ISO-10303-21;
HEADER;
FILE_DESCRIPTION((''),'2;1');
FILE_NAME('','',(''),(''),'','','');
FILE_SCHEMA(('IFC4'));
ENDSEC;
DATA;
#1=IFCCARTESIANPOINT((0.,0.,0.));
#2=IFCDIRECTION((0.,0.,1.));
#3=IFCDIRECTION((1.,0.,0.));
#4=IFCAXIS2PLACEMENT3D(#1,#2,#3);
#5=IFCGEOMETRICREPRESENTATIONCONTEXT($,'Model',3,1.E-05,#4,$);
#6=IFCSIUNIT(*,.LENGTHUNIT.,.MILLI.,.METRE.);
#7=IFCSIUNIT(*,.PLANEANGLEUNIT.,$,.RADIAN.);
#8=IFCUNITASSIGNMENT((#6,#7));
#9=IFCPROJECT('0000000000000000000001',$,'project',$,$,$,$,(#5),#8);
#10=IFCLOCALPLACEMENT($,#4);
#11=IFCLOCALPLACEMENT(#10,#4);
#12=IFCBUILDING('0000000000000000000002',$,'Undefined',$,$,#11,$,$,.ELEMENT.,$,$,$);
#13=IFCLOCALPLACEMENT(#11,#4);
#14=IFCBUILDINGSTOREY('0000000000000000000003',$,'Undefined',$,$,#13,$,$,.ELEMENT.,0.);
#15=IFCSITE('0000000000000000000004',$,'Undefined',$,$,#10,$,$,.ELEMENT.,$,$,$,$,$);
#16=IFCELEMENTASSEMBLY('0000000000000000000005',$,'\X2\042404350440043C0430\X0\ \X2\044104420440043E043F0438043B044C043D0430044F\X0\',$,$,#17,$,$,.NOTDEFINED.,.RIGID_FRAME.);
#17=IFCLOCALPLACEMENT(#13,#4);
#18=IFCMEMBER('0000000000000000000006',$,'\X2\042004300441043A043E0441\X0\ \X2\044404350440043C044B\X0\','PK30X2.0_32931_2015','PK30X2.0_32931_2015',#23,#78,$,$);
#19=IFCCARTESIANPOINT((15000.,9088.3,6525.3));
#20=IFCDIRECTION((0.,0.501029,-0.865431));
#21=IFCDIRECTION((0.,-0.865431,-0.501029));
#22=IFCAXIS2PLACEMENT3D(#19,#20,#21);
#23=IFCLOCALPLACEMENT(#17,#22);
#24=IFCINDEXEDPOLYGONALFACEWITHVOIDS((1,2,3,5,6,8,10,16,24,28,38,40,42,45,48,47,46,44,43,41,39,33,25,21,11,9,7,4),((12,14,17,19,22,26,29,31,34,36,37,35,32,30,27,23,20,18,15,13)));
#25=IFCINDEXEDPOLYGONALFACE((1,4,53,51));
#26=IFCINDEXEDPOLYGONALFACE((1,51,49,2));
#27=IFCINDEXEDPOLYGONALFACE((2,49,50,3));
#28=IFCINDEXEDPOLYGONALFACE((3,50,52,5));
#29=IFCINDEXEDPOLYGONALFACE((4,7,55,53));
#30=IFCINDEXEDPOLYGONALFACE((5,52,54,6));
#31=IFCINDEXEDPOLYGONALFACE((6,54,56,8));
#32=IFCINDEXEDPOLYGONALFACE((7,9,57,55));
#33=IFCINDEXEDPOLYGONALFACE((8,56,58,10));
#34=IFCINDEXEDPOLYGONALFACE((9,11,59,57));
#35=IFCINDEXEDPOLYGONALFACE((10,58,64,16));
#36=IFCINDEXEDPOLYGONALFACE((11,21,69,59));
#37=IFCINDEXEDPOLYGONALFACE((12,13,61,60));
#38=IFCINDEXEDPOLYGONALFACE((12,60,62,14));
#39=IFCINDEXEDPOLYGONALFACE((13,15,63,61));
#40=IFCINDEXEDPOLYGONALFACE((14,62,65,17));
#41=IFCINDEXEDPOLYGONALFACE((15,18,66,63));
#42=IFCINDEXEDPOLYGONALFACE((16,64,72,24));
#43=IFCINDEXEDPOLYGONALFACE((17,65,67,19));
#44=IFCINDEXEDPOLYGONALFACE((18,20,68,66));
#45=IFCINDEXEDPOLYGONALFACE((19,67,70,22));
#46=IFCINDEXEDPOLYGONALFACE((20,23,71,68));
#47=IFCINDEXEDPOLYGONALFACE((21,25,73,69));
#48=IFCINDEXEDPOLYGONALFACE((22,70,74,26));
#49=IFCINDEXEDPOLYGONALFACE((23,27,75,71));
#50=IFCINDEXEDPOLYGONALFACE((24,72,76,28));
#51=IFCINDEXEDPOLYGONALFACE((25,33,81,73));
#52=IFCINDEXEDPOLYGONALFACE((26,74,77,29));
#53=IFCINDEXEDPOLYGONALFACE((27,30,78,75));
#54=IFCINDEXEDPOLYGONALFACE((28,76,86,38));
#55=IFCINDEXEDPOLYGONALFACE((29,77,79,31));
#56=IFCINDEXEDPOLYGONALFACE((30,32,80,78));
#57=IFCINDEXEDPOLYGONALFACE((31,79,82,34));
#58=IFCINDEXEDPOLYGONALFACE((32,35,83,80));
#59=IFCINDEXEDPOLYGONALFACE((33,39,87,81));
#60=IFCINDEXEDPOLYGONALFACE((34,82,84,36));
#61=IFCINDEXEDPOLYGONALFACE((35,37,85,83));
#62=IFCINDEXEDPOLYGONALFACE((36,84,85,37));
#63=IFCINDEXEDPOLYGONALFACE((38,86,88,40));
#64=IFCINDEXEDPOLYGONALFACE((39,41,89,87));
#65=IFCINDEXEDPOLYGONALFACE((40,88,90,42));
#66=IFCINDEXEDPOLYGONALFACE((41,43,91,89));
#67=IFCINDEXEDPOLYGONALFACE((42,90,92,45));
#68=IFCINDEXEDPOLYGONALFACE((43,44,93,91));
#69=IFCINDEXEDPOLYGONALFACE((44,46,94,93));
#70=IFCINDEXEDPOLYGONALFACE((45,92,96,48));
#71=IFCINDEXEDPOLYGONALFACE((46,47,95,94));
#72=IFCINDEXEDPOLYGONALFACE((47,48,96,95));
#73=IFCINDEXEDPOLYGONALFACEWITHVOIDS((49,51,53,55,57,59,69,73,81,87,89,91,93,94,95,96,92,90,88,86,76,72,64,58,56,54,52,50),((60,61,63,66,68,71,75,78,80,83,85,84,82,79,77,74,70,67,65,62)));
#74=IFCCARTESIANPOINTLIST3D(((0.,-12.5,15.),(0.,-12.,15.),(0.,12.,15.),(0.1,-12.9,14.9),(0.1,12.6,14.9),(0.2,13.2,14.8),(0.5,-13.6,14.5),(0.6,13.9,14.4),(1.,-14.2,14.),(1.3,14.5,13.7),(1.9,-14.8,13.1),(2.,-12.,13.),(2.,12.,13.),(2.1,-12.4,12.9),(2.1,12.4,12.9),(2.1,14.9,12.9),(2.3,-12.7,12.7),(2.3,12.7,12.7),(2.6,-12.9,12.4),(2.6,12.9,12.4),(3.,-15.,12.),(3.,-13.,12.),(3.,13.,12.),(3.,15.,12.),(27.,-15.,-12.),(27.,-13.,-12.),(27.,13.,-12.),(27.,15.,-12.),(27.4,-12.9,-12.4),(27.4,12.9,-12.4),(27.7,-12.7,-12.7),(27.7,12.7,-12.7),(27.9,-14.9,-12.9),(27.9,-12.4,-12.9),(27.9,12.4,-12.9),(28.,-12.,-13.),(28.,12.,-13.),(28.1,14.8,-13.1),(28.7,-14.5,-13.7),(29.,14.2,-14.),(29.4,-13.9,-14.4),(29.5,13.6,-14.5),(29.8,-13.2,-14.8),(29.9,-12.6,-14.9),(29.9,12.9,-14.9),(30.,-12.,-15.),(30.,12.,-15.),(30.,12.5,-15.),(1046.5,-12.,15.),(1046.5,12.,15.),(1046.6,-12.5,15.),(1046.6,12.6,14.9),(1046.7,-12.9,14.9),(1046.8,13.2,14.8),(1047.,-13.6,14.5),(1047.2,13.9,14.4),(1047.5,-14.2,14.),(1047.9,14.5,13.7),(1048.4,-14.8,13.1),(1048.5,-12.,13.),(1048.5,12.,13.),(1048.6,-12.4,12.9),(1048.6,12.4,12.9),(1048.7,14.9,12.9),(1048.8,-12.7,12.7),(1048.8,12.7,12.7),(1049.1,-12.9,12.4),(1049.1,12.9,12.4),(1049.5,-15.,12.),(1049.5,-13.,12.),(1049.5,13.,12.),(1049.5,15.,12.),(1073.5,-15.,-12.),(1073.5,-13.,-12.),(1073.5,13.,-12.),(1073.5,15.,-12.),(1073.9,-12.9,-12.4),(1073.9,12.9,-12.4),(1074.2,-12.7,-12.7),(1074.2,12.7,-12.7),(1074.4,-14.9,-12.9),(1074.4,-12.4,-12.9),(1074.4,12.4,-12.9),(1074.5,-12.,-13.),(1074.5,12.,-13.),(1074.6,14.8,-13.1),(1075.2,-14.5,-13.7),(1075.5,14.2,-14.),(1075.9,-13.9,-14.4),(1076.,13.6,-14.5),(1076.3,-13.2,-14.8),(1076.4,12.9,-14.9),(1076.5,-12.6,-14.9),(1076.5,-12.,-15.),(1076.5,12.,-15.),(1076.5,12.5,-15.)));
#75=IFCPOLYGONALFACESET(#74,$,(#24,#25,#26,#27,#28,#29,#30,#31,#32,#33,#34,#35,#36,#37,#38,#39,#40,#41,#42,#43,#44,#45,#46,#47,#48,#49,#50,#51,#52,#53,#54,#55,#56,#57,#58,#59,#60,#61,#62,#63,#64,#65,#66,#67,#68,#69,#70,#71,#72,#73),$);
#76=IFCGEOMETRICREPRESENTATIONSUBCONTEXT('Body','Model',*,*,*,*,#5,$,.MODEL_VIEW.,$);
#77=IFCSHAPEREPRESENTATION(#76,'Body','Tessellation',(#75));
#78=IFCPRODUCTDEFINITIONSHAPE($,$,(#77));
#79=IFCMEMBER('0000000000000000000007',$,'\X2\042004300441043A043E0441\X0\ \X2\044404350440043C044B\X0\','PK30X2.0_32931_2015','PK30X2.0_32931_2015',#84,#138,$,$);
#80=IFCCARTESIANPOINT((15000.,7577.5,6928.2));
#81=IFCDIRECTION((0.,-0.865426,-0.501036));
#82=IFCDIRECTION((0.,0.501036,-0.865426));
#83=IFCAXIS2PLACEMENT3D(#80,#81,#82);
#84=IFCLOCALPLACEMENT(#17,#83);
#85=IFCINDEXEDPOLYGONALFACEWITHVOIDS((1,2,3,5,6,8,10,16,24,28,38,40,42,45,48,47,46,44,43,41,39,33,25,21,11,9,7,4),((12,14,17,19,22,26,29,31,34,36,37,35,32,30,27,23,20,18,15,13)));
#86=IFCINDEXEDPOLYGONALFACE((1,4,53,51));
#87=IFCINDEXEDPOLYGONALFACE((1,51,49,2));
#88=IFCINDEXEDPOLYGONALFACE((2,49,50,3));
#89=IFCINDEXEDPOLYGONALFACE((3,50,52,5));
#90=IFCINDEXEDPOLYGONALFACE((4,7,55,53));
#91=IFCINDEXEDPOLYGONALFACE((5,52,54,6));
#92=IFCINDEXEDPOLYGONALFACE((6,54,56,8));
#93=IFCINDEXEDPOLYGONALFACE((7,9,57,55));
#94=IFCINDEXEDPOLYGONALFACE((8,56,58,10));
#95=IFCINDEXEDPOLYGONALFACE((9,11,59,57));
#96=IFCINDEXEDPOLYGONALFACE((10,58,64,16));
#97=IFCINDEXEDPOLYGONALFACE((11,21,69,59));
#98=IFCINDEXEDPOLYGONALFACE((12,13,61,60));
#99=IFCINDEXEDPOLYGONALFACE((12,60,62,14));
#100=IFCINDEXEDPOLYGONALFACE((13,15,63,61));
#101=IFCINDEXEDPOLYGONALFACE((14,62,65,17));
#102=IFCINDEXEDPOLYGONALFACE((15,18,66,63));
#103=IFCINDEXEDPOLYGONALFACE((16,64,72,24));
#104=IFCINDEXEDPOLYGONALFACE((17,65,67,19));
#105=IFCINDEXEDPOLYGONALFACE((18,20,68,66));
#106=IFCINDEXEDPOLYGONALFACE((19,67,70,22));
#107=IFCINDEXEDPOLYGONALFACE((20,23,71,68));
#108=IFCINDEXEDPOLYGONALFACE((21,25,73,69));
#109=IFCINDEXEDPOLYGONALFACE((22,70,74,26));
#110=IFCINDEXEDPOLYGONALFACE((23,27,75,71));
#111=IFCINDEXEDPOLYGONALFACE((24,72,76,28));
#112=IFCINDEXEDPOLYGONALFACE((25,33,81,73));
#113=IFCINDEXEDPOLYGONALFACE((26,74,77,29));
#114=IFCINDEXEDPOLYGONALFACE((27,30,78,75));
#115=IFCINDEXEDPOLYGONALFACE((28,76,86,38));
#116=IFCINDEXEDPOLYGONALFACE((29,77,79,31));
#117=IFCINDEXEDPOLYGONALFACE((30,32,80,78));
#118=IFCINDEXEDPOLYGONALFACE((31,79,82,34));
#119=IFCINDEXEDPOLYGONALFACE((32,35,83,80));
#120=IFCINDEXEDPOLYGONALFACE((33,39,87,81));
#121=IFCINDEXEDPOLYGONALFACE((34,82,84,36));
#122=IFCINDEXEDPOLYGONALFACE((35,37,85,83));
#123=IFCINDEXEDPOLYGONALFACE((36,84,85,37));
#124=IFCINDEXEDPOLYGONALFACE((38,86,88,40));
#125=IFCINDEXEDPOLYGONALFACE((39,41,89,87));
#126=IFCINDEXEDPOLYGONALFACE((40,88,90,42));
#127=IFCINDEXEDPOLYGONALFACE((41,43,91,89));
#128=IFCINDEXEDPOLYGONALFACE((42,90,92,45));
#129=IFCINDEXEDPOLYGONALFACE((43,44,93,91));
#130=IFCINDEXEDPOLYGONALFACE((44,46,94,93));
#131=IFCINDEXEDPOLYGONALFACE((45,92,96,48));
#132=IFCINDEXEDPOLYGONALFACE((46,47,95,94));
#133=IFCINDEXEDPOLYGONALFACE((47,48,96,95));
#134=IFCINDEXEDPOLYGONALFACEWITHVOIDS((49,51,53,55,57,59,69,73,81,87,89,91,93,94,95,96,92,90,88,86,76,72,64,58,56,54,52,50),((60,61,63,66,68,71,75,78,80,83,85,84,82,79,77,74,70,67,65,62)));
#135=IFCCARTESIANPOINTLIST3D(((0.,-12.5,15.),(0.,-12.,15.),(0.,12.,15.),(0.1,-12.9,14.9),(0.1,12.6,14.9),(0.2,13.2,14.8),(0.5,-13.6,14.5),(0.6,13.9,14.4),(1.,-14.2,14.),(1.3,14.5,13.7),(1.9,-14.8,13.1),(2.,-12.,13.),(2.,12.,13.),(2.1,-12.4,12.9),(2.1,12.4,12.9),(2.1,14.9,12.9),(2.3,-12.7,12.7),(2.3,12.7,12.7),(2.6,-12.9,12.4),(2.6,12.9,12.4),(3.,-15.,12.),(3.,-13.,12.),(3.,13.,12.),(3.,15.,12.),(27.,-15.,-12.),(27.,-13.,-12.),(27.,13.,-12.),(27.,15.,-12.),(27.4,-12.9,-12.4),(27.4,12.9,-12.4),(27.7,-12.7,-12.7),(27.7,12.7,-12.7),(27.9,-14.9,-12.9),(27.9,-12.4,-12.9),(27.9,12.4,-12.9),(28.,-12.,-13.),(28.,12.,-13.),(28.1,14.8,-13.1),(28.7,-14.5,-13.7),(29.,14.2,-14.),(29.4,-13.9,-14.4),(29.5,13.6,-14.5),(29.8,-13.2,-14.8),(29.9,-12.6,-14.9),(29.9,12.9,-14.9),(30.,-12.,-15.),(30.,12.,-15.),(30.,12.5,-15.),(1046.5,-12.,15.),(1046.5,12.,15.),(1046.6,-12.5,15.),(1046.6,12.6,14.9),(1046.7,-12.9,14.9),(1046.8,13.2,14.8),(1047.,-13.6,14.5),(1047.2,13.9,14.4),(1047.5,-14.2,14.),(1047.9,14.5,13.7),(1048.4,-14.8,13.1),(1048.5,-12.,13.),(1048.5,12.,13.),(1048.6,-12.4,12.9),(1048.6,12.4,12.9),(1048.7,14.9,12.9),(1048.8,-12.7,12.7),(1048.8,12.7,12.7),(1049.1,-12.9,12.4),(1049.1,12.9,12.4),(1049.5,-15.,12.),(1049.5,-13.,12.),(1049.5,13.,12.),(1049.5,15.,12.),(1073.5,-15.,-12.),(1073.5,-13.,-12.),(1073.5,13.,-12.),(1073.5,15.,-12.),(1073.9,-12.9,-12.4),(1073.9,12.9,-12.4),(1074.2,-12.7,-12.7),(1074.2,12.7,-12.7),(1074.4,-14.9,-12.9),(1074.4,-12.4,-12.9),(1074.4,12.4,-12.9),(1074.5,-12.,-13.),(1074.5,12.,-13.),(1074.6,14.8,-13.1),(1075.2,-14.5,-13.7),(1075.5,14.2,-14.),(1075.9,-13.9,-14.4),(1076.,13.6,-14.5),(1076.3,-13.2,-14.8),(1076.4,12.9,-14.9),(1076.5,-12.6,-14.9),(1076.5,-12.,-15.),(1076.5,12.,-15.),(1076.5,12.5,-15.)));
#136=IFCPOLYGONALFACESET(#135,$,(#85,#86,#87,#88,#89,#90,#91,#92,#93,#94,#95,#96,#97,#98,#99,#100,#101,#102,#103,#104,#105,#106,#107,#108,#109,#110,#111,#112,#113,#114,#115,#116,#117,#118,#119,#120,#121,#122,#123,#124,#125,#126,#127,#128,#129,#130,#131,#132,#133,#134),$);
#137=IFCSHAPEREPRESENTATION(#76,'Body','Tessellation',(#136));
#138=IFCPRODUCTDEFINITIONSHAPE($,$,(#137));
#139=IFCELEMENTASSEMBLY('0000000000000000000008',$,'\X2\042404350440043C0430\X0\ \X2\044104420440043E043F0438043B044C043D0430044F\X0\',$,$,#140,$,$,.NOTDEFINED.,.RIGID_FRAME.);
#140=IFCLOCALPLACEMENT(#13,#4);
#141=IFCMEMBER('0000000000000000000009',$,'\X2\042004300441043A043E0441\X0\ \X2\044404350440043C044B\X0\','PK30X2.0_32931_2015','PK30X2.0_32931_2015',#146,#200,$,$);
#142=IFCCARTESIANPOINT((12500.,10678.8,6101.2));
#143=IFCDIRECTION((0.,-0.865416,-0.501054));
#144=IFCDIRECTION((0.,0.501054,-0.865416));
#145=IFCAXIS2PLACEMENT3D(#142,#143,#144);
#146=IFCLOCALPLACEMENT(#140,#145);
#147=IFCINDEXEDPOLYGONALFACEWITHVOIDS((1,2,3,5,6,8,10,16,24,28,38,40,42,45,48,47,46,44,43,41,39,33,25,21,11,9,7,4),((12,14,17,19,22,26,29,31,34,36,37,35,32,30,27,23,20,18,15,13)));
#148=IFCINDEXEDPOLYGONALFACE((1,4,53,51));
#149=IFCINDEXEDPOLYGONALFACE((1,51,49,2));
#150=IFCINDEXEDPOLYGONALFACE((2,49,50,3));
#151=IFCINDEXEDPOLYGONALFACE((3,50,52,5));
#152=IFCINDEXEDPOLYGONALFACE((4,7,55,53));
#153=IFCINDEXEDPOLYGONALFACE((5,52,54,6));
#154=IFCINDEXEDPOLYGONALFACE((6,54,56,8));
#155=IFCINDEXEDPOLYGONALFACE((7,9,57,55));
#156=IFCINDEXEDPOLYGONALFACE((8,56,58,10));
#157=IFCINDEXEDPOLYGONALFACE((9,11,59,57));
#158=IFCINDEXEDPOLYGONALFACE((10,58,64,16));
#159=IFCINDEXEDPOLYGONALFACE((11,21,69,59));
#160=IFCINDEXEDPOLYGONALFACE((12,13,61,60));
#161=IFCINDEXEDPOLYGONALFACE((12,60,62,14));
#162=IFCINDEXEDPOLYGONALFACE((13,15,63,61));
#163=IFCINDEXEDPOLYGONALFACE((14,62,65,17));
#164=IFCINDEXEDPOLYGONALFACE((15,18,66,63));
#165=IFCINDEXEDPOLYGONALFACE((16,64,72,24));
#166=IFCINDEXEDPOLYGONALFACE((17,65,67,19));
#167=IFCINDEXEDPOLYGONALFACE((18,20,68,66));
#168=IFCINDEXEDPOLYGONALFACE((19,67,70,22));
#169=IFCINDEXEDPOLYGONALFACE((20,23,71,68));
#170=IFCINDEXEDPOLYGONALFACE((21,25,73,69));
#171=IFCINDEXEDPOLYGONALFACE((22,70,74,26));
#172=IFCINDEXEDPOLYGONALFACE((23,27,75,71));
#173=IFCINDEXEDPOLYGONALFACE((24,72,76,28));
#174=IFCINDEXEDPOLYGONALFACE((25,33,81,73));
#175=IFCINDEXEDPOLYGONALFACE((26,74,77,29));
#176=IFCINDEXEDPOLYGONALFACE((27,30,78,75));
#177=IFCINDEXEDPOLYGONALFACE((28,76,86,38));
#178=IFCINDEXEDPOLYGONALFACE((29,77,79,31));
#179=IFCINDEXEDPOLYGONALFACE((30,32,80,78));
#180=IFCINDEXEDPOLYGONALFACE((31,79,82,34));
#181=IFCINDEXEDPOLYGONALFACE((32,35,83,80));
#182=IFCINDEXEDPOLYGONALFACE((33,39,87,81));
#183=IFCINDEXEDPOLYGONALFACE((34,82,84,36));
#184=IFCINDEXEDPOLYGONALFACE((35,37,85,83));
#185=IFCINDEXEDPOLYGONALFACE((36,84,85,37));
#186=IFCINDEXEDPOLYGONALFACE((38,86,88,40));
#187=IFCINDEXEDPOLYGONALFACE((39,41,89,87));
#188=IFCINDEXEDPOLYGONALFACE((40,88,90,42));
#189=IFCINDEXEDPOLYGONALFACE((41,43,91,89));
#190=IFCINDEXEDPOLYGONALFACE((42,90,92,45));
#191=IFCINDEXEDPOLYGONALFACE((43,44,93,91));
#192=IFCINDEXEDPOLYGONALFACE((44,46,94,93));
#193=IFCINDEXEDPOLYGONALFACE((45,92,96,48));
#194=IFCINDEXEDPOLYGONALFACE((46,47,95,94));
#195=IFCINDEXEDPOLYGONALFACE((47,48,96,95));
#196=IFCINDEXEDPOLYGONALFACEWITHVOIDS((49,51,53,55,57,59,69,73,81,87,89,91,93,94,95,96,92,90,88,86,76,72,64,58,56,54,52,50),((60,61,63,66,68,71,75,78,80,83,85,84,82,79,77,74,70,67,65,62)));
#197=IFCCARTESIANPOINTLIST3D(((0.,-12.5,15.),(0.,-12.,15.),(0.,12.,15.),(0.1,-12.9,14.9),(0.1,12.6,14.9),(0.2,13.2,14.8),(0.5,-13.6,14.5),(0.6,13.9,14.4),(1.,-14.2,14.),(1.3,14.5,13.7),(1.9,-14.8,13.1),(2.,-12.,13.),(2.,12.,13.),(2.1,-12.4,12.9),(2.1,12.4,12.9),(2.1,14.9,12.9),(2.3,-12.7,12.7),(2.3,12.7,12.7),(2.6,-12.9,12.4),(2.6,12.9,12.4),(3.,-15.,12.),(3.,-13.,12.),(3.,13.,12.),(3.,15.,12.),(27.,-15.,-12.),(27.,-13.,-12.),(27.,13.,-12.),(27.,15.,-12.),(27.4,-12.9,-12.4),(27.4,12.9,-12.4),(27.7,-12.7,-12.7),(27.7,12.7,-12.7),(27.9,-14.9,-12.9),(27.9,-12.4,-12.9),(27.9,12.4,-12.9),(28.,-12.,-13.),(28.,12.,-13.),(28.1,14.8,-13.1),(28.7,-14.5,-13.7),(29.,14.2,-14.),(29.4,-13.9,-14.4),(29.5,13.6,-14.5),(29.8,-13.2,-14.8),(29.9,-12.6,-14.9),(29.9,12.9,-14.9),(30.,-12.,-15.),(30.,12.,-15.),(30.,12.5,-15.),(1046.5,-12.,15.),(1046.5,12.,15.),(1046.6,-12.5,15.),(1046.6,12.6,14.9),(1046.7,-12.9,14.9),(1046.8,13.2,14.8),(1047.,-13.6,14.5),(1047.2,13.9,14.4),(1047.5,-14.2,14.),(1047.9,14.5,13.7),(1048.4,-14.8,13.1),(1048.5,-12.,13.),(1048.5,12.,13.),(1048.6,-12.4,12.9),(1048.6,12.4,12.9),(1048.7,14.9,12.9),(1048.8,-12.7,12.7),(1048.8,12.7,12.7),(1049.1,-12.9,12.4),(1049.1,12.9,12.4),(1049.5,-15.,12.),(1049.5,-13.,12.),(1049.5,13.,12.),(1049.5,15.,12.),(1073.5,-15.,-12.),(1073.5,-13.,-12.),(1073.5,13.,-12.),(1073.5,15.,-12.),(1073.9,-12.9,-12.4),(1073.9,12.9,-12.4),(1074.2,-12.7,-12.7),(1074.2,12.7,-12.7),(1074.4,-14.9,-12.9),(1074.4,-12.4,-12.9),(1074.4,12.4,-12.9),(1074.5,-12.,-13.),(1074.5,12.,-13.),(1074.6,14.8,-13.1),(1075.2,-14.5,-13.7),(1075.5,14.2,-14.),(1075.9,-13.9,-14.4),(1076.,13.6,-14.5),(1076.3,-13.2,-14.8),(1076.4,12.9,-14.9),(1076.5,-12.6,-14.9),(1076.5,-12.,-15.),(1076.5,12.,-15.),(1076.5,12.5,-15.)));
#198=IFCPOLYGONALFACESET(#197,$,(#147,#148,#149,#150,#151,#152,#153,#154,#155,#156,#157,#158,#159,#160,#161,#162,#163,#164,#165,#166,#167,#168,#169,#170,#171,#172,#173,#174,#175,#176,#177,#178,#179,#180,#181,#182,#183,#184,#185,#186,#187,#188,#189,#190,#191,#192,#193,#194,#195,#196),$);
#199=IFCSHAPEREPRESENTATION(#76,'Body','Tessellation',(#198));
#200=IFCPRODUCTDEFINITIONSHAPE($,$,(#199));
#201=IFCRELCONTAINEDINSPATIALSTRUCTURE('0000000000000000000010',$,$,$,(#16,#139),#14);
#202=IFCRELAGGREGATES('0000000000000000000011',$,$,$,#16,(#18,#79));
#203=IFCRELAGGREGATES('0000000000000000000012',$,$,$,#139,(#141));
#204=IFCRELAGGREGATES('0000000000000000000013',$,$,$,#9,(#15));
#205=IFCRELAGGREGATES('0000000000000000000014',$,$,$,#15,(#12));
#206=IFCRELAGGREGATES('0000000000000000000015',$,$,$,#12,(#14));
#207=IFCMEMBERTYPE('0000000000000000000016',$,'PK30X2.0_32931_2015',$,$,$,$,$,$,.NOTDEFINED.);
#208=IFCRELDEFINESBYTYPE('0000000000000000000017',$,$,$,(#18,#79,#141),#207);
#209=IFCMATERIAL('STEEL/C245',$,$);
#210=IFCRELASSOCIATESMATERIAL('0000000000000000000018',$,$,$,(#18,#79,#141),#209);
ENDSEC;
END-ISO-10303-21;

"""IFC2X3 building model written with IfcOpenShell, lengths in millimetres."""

from ifc_helpers import new_model, si_unit, frame, origin_with_axes, origin_2d_with_axis, place, context, subcontext, project, spatial, hollow_rectangle, extrude, clip, halfspace, material, type_object, element, aggregate, save


model = new_model("IFC2X3")

# Units and contexts
model_context = context("Model", 3, precision=1e-05, world=origin_with_axes())
body_context = subcontext(model_context, "Body", "Model", "MODEL_VIEW")
ifc_project = project(units=[si_unit("LENGTHUNIT", "METRE", prefix="MILLI"), si_unit("PLANEANGLEUNIT", "RADIAN")], contexts=[model_context])

# Site, building, storey
site_placement = place(None, origin_with_axes())
site = spatial("IfcSite", under=ifc_project, at=site_placement, Name="Undefined", CompositionType="ELEMENT")
building_placement = place(site_placement, origin_with_axes())
building = spatial("IfcBuilding", under=site, at=building_placement, Name="Undefined", CompositionType="ELEMENT")
storey_placement = place(building_placement, origin_with_axes())
storey = spatial("IfcBuildingStorey", under=building, at=storey_placement, Name="Undefined", CompositionType="ELEMENT", Elevation=0.0)

# Element assembly
assembly_1_placement = place(storey_placement, origin_with_axes())
assembly_1 = element("IfcElementAssembly", 1, at=assembly_1_placement, inside=storey, Name="Ферма стропильная", AssemblyPlace="NOTDEFINED", PredefinedType="RIGID_FRAME")
ifc_material_1 = material(Name="STEEL/C245")

# Members
member_type = type_object("IfcMemberType", Name="PK30X2.0_32931_2015", PredefinedType="NOTDEFINED")
member_1_placement = place(assembly_1_placement, frame((15000.0, 9088.3, 6525.3), z_axis=(0.0, 0.501029, -0.865431), x_axis=(0.0, -0.865431, -0.501029)))
member_1 = element("IfcMember", 2, at=member_1_placement, type_object=member_type, material=ifc_material_1, Name="Раскос фермы", Description="PK30X2.0_32931_2015", ObjectType="PK30X2.0_32931_2015", context=body_context, shape_type="Clipping", body=[
    clip(clip(extrude(hollow_rectangle(XDim=30.0, YDim=30.0, WallThickness=2.0, InnerFilletRadius=1.0, OuterFilletRadius=3.0, at=origin_2d_with_axis()), frame((1102.9, 0.0, 0.0), z_axis=(-1.0, 0.0, 0.0), x_axis=(0.0, -1.0, 0.0)), (0.0, 0.0, 1.0), 1129.2), halfspace(frame((1060.0, 0.0, 1.5), z_axis=(-0.707107, 0.0, -0.707107), x_axis=(0.707107, 0.0, -0.707107)), True)), halfspace(frame((34.5, 0.0, -19.5), z_axis=(-0.707107, 0.0, -0.707107), x_axis=(0.707107, 0.0, -0.707107)), False)),
])
member_2_placement = place(assembly_1_placement, frame((15000.0, 7577.5, 6928.2), z_axis=(0.0, -0.865426, -0.501036), x_axis=(0.0, 0.501036, -0.865426)))
member_2 = element("IfcMember", 3, at=member_2_placement, type_object=member_type, material=ifc_material_1, Name="Раскос фермы", Description="PK30X2.0_32931_2015", ObjectType="PK30X2.0_32931_2015", context=body_context, shape_type="Clipping", body=[
    clip(clip(extrude(hollow_rectangle(XDim=30.0, YDim=30.0, WallThickness=2.0, InnerFilletRadius=1.0, OuterFilletRadius=3.0, at=origin_2d_with_axis()), frame((1091.8, 0.0, 0.0), z_axis=(-1.0, 0.0, 0.0), x_axis=(0.0, -1.0, 0.0)), (0.0, 0.0, 1.0), 1107.1), halfspace(frame((1060.0, 0.0, 1.5), z_axis=(-0.707107, 0.0, -0.707107), x_axis=(0.707107, 0.0, -0.707107)), True)), halfspace(frame((34.5, 0.0, -19.5), z_axis=(-0.707107, 0.0, -0.707107), x_axis=(0.707107, 0.0, -0.707107)), False)),
])
aggregate(assembly_1, [member_1, member_2])

# Element assembly, member
assembly_2_placement = place(storey_placement, origin_with_axes())
assembly_2 = element("IfcElementAssembly", 4, at=assembly_2_placement, inside=storey, Name="Ферма стропильная", AssemblyPlace="NOTDEFINED", PredefinedType="RIGID_FRAME")
member_3_placement = place(assembly_2_placement, frame((12500.0, 10678.8, 6101.2), z_axis=(0.0, -0.865416, -0.501054), x_axis=(0.0, 0.501054, -0.865416)))
member_3 = element("IfcMember", 5, at=member_3_placement, type_object=member_type, material=ifc_material_1, Name="Раскос фермы", Description="PK30X2.0_32931_2015", ObjectType="PK30X2.0_32931_2015", context=body_context, shape_type="Clipping", body=[
    clip(clip(extrude(hollow_rectangle(XDim=30.0, YDim=30.0, WallThickness=2.0, InnerFilletRadius=1.0, OuterFilletRadius=3.0, at=origin_2d_with_axis()), frame((1091.8, 0.0, 0.0), z_axis=(-1.0, 0.0, 0.0), x_axis=(0.0, -1.0, 0.0)), (0.0, 0.0, 1.0), 1107.1), halfspace(frame((1060.0, 0.0, 1.5), z_axis=(-0.707107, 0.0, -0.707107), x_axis=(0.707107, 0.0, -0.707107)), True)), halfspace(frame((34.5, 0.0, -19.5), z_axis=(-0.707107, 0.0, -0.707107), x_axis=(0.707107, 0.0, -0.707107)), False)),
])
aggregate(assembly_2, [member_3])

save(model, "model.ifc")
